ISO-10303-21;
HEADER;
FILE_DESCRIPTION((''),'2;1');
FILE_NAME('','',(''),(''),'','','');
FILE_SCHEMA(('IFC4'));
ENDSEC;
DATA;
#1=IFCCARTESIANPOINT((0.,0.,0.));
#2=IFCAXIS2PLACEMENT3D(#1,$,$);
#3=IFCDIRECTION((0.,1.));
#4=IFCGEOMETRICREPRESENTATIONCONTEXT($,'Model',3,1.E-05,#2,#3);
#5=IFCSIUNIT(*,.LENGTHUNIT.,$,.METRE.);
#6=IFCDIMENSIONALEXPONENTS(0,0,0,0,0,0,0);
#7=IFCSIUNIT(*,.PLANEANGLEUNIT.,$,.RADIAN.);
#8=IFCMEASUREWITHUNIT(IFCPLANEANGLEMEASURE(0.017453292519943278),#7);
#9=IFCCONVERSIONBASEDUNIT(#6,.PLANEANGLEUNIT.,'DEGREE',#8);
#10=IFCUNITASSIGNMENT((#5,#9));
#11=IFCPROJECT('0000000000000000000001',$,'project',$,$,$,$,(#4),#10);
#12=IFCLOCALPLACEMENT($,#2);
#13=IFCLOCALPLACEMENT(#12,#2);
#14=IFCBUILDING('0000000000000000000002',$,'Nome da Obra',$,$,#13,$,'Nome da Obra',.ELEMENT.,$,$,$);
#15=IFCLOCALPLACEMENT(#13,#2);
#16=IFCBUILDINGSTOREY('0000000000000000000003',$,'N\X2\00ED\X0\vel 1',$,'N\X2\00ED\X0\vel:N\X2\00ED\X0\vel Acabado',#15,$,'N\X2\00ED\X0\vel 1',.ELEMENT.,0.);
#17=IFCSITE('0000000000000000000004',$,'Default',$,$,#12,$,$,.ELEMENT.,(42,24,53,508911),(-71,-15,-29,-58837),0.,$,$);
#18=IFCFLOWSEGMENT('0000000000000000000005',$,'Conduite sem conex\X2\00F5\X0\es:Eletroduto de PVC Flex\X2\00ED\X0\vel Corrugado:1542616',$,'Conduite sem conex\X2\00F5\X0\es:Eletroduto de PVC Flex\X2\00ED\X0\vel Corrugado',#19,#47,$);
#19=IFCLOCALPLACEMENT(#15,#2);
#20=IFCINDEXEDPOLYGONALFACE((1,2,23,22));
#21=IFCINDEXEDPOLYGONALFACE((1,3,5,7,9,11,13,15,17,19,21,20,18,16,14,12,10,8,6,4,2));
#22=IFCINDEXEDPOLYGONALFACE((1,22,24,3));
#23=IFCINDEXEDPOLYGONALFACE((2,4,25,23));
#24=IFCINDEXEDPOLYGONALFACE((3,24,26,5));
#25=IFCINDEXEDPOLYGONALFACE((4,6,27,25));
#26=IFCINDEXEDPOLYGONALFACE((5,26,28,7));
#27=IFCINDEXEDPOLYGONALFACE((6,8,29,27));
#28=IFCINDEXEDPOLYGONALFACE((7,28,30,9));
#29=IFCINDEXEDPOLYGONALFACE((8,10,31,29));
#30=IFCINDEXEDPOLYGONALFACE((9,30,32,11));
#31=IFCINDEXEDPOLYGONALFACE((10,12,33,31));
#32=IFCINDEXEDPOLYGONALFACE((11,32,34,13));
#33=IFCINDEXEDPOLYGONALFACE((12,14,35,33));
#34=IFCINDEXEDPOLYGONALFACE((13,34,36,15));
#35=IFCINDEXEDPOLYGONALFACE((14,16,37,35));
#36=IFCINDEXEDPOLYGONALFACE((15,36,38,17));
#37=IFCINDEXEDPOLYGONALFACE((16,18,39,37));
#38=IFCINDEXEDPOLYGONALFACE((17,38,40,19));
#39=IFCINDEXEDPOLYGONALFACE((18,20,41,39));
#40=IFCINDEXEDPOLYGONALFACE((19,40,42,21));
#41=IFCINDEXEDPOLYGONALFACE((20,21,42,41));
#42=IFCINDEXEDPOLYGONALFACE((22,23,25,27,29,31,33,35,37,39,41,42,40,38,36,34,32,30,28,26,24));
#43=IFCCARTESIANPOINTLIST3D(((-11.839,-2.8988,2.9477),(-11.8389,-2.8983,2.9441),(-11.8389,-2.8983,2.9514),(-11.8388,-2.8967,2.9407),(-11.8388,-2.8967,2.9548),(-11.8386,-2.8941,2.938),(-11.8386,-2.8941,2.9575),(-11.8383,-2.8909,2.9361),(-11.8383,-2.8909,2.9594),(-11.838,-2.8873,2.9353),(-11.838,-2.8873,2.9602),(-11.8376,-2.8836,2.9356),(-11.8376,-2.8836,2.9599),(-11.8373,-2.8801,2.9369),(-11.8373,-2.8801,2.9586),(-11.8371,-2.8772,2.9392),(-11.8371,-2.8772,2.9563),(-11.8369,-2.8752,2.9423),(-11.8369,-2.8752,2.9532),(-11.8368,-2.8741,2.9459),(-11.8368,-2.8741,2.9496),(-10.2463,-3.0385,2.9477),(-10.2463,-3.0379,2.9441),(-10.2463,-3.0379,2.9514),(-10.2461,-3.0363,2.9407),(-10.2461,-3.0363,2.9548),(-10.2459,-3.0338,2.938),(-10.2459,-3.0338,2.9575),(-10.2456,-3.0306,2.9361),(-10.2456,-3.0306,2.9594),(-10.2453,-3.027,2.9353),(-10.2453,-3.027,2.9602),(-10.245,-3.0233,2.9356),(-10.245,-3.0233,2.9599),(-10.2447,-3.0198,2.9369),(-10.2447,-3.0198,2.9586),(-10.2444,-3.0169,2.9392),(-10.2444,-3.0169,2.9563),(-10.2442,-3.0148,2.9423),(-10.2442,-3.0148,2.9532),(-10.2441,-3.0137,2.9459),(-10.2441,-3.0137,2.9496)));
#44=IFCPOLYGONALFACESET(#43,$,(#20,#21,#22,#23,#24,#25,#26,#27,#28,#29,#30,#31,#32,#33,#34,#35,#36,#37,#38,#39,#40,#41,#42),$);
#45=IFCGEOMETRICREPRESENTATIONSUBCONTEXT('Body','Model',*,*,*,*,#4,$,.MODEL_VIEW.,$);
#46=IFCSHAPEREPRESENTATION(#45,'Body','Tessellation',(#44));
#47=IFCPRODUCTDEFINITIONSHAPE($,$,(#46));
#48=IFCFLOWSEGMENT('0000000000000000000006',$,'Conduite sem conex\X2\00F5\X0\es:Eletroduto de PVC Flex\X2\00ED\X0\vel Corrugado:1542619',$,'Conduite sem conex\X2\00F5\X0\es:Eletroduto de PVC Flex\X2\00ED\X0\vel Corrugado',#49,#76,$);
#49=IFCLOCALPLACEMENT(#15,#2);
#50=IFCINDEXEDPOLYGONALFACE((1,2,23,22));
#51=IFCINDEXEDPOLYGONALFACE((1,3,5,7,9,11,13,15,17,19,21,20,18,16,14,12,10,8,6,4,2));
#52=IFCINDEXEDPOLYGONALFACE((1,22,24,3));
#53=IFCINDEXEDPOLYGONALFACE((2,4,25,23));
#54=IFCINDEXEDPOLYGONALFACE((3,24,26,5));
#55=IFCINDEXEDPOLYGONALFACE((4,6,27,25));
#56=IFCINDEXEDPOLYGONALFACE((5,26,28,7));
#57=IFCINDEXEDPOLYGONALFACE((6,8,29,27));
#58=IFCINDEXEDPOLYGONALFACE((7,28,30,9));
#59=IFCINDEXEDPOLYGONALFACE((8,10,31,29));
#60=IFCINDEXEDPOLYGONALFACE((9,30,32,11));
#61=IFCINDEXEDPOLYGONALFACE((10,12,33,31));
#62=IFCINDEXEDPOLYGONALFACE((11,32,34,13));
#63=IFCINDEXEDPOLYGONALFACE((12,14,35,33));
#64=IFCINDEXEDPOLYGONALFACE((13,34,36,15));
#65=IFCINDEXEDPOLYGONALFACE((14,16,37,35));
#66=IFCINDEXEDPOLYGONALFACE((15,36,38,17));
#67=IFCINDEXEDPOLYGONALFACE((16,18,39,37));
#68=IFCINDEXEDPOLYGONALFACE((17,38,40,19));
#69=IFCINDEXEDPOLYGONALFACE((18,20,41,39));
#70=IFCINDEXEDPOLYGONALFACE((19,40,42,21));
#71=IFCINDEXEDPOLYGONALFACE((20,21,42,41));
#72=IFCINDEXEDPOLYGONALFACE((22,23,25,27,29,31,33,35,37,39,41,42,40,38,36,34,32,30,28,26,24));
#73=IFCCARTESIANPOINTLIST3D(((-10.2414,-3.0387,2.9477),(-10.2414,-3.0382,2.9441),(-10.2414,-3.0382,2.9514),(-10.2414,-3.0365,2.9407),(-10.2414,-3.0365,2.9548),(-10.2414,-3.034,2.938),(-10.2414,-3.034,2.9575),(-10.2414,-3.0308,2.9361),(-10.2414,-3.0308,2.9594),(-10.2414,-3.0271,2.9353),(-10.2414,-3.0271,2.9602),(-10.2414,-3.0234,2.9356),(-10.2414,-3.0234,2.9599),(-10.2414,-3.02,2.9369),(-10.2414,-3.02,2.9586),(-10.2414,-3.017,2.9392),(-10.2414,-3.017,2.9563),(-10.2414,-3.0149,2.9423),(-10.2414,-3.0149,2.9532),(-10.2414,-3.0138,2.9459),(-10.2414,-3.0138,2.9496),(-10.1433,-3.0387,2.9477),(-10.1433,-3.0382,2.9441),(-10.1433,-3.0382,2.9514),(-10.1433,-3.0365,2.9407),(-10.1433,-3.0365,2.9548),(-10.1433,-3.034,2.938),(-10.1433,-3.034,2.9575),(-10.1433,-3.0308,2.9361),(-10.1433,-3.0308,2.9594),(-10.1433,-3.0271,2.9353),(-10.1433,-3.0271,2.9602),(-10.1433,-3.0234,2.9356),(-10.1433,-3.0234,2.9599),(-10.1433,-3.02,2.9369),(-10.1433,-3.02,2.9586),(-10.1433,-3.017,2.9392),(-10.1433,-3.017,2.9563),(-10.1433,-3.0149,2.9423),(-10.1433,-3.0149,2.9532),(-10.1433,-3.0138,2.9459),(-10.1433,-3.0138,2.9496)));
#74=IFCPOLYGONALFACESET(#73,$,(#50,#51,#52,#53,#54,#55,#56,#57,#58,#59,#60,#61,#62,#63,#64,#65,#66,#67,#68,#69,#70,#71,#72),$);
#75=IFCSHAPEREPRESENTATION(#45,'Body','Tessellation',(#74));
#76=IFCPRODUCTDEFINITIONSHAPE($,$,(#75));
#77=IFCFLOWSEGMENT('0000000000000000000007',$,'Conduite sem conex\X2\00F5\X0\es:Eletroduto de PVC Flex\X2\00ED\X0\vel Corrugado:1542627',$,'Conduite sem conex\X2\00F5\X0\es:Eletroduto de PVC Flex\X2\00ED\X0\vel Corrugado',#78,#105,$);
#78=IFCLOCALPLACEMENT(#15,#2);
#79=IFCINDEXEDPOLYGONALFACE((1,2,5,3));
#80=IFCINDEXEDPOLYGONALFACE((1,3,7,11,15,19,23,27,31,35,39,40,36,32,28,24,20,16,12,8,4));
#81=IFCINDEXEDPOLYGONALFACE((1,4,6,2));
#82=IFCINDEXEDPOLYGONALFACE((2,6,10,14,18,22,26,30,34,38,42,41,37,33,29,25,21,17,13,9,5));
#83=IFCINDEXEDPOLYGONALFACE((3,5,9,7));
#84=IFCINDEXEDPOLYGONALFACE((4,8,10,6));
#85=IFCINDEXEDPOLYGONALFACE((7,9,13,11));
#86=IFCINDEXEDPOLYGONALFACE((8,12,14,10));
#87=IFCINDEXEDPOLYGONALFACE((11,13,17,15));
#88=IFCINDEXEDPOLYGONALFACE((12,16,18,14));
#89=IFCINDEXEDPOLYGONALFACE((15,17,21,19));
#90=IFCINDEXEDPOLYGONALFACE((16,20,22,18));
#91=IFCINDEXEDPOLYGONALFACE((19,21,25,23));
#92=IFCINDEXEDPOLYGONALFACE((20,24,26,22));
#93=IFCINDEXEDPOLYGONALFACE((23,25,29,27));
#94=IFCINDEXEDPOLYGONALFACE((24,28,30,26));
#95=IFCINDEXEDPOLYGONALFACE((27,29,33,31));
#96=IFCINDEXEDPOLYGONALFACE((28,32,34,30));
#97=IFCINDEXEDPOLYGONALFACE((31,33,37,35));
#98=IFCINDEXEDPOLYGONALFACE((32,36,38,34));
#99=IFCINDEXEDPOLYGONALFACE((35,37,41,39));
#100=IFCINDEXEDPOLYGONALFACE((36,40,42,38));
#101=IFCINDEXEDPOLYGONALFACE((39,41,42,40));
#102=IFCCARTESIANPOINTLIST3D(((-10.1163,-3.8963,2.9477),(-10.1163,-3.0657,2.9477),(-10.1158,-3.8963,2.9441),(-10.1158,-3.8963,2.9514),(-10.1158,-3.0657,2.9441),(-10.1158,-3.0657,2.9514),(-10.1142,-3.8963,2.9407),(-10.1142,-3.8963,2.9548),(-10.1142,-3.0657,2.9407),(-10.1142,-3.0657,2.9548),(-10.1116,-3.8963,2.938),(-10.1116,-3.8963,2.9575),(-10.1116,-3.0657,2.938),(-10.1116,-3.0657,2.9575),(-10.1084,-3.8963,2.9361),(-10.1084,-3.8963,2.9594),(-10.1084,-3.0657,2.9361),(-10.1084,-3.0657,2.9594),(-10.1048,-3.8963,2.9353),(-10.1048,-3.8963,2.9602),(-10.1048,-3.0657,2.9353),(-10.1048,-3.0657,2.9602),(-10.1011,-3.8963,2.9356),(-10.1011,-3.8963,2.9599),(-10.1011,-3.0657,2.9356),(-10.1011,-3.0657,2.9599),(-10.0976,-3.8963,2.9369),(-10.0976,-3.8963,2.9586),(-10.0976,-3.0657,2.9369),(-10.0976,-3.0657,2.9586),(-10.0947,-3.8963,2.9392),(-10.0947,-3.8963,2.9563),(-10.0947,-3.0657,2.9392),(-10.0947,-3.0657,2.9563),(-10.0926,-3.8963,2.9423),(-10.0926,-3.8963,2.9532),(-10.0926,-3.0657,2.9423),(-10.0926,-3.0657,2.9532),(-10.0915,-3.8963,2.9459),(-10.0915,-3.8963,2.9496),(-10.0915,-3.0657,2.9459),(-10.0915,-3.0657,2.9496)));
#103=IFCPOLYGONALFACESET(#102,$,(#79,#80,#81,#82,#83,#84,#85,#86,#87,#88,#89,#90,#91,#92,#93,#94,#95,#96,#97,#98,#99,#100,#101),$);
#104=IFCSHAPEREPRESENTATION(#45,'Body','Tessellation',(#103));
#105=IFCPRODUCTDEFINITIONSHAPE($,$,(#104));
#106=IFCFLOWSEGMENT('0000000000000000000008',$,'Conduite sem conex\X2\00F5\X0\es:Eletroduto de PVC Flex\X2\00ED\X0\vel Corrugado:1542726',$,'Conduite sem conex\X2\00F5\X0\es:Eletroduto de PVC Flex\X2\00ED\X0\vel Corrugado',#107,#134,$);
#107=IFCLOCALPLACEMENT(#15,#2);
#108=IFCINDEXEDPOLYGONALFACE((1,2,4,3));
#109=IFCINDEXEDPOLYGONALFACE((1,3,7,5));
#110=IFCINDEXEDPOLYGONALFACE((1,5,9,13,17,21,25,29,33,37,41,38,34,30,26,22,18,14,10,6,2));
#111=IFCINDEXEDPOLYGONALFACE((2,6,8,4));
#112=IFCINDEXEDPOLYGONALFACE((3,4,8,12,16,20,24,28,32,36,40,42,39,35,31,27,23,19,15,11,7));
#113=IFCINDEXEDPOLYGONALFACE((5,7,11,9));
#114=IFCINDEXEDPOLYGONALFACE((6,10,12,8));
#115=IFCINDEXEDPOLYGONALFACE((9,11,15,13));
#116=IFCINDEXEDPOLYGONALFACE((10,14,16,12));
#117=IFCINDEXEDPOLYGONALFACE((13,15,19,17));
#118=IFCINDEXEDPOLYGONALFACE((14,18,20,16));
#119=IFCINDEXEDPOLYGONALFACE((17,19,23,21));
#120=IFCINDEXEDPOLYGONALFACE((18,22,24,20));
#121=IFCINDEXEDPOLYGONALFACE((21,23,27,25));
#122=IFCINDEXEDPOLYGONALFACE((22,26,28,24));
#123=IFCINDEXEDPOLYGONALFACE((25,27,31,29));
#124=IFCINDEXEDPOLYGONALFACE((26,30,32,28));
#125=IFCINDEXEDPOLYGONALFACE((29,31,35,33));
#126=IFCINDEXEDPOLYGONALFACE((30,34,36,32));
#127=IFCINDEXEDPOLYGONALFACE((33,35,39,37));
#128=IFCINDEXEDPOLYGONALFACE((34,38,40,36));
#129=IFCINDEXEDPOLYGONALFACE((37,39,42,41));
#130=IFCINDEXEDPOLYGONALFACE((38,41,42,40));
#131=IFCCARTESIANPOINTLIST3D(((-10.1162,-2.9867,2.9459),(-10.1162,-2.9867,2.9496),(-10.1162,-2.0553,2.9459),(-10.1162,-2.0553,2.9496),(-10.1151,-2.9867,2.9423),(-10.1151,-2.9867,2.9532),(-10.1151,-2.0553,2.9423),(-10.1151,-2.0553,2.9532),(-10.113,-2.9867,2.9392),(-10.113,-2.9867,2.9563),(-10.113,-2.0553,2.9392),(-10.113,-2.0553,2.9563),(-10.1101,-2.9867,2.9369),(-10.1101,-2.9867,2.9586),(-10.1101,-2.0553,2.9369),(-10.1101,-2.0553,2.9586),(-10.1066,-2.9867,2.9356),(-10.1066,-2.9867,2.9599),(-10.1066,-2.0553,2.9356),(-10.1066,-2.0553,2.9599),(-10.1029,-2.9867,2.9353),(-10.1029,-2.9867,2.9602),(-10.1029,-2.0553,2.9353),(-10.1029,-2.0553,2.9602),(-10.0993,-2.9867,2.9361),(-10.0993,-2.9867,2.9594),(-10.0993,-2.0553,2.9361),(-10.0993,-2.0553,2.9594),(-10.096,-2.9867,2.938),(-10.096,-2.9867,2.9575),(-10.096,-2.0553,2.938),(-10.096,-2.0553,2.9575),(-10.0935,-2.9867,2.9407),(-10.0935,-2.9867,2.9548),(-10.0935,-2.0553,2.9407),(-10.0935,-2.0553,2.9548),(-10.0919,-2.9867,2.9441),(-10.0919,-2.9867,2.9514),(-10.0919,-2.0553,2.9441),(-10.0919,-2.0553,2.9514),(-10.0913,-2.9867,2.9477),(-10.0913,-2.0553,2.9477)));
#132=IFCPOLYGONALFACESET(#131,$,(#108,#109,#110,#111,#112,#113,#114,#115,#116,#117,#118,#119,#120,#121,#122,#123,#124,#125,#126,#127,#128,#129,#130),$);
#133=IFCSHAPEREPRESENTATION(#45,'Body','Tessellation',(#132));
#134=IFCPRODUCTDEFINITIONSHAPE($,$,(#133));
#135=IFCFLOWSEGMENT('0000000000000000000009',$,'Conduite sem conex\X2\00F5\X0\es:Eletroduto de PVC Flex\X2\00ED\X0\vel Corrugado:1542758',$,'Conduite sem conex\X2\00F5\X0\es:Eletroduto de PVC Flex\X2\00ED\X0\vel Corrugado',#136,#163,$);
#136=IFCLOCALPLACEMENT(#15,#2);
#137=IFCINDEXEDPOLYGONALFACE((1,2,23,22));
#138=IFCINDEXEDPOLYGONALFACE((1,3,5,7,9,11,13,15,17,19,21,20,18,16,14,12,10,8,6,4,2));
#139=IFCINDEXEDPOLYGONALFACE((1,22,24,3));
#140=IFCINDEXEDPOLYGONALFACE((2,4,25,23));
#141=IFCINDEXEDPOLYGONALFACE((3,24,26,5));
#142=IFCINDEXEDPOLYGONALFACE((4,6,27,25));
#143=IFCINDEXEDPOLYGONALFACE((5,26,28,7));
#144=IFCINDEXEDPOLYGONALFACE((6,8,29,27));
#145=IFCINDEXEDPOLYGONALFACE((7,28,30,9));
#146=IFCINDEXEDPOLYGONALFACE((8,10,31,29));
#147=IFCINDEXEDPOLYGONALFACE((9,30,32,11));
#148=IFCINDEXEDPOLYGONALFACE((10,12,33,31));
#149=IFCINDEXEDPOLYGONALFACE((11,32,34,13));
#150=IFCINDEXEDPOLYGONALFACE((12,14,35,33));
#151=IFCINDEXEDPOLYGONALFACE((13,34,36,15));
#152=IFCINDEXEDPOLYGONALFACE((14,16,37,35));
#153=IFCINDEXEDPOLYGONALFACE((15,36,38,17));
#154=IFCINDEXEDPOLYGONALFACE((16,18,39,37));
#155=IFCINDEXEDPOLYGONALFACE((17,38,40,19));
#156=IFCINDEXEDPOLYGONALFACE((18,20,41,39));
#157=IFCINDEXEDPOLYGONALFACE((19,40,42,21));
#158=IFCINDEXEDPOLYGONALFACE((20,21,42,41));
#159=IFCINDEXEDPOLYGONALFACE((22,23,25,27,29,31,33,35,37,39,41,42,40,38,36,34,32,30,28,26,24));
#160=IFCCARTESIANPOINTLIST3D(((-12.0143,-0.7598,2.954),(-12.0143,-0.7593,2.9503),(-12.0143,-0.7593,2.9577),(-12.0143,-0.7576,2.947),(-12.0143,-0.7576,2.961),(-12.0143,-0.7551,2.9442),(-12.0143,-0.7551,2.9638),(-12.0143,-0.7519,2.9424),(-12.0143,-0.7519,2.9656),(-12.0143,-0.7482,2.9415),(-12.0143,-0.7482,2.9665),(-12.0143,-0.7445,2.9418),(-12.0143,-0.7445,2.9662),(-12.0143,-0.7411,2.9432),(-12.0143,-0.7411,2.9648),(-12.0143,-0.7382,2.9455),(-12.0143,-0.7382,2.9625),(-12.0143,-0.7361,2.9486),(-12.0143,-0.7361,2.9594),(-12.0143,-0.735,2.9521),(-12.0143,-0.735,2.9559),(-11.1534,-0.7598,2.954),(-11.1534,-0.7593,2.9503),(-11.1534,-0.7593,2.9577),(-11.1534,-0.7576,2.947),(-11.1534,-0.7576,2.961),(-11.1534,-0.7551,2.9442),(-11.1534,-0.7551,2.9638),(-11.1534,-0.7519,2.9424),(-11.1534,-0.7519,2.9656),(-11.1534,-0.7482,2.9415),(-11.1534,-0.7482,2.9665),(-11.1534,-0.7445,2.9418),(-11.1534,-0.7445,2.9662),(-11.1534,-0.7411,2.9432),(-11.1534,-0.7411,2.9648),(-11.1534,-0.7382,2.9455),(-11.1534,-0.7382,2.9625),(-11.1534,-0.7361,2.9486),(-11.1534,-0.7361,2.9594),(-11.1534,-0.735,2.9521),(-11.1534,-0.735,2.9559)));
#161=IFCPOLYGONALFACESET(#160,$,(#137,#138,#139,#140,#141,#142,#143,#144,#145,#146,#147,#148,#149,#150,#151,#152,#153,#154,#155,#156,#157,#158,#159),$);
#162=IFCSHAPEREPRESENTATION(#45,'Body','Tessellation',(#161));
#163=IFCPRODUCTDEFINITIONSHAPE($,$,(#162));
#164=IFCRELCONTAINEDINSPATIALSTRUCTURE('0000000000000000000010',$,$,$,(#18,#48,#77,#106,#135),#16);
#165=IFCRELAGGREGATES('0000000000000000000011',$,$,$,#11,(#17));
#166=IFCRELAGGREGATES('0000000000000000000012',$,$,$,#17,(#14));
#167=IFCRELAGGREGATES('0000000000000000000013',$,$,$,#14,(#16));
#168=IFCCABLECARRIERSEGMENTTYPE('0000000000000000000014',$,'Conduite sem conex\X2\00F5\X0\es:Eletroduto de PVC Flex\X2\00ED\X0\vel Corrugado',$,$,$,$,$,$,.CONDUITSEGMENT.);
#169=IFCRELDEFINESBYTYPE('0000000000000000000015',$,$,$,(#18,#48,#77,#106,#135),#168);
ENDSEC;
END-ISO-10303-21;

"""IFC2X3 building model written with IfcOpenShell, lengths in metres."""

from ifc_helpers import new_model, entity, si_unit, converted_unit, direction, frame, frame_2d, origin, origin_2d_with_axis, place, context, subcontext, project, spatial, circle, extrude, type_object, element, save


model = new_model("IFC2X3")

# Units and contexts
model_context = context("Model", 3, precision=1e-05, world=origin(), true_north=direction((0.0, 1.0)))
body_context = subcontext(model_context, "Body", "Model", "MODEL_VIEW")
ifc_project = project(units=[si_unit("LENGTHUNIT", "METRE"), converted_unit("PLANEANGLEUNIT", "DEGREE", entity("IfcPlaneAngleMeasure", 0.017453292519943278), si_unit("PLANEANGLEUNIT", "RADIAN"), dimensions=[0, 0, 0, 0, 0, 0, 0])], contexts=[model_context])

# Site, building, storey
site_placement = place(None, origin())
site = spatial("IfcSite", under=ifc_project, at=site_placement, Name="Default", CompositionType="ELEMENT", RefLatitude=(42, 24, 53, 508911), RefLongitude=(-71, -15, -29, -58837), RefElevation=0.0)
building_placement = place(site_placement, origin())
building = spatial("IfcBuilding", under=site, at=building_placement, Name="Nome da Obra", LongName="Nome da Obra", CompositionType="ELEMENT")
storey_placement = place(building_placement, origin())
storey = spatial("IfcBuildingStorey", under=building, at=storey_placement, Name="Nível 1", ObjectType="Nível:Nível Acabado", LongName="Nível 1", CompositionType="ELEMENT", Elevation=0.0)

# Flow segments
cable_carrier_segment_type = type_object("IfcCableCarrierSegmentType", Name="Conduite sem conexões:Eletroduto de PVC Flexível Corrugado", PredefinedType="CONDUITSEGMENT")
flow_segment_1_placement = place(storey_placement, origin())
element("IfcFlowSegment", 1, at=flow_segment_1_placement, inside=storey, type_object=cable_carrier_segment_type, Name="Conduite sem conexões:Eletroduto de PVC Flexível Corrugado:1542616", ObjectType="Conduite sem conexões:Eletroduto de PVC Flexível Corrugado", context=body_context, shape_type="SweptSolid", body=[
    extrude(circle(Radius=0.0125, at=origin_2d_with_axis()), frame((-11.8379, -2.8864, 2.9477), z_axis=(0.996177, -0.08736, 0.0), x_axis=(-0.08736, -0.996177, 0.0)), (0.0, 0.0, 1.0), 1.5988),
])
flow_segment_2_placement = place(storey_placement, origin())
element("IfcFlowSegment", 2, at=flow_segment_2_placement, inside=storey, type_object=cable_carrier_segment_type, Name="Conduite sem conexões:Eletroduto de PVC Flexível Corrugado:1542619", ObjectType="Conduite sem conexões:Eletroduto de PVC Flexível Corrugado", context=body_context, shape_type="SweptSolid", body=[
    extrude(circle(Radius=0.0125, at=origin_2d_with_axis()), frame((-10.2414, -3.0262, 2.9477), z_axis=(1.0, 0.0, 0.0), x_axis=(0.0, -1.0, 0.0)), (0.0, 0.0, 1.0), 0.0981),
])
flow_segment_3_placement = place(storey_placement, origin())
element("IfcFlowSegment", 3, at=flow_segment_3_placement, inside=storey, type_object=cable_carrier_segment_type, Name="Conduite sem conexões:Eletroduto de PVC Flexível Corrugado:1542627", ObjectType="Conduite sem conexões:Eletroduto de PVC Flexível Corrugado", context=body_context, shape_type="SweptSolid", body=[
    extrude(circle(Radius=0.0125, at=frame_2d((0.0, 0.0), x_axis=(1.0, 0.0))), frame((-10.1038, -3.8963, 2.9477), z_axis=(0.0, 1.0, 0.0), x_axis=(-1.0, 0.0, 0.0)), (0.0, 0.0, 1.0), 0.8306),
])
flow_segment_4_placement = place(storey_placement, origin())
element("IfcFlowSegment", 4, at=flow_segment_4_placement, inside=storey, type_object=cable_carrier_segment_type, Name="Conduite sem conexões:Eletroduto de PVC Flexível Corrugado:1542726", ObjectType="Conduite sem conexões:Eletroduto de PVC Flexível Corrugado", context=body_context, shape_type="SweptSolid", body=[
    extrude(circle(Radius=0.0125, at=origin_2d_with_axis()), frame((-10.1038, -2.9867, 2.9477), z_axis=(0.0, 1.0, 0.0), x_axis=(1.0, 0.0, 0.0)), (0.0, 0.0, 1.0), 0.9314),
])
flow_segment_5_placement = place(storey_placement, origin())
element("IfcFlowSegment", 5, at=flow_segment_5_placement, inside=storey, type_object=cable_carrier_segment_type, Name="Conduite sem conexões:Eletroduto de PVC Flexível Corrugado:1542758", ObjectType="Conduite sem conexões:Eletroduto de PVC Flexível Corrugado", context=body_context, shape_type="SweptSolid", body=[
    extrude(circle(Radius=0.0125, at=frame_2d((0.0, 0.0), x_axis=(1.0, 0.0))), frame((-12.0143, -0.7473, 2.954), z_axis=(1.0, 0.0, 0.0), x_axis=(0.0, -1.0, 0.0)), (0.0, 0.0, 1.0), 0.8608),
])

save(model, "model.ifc")
